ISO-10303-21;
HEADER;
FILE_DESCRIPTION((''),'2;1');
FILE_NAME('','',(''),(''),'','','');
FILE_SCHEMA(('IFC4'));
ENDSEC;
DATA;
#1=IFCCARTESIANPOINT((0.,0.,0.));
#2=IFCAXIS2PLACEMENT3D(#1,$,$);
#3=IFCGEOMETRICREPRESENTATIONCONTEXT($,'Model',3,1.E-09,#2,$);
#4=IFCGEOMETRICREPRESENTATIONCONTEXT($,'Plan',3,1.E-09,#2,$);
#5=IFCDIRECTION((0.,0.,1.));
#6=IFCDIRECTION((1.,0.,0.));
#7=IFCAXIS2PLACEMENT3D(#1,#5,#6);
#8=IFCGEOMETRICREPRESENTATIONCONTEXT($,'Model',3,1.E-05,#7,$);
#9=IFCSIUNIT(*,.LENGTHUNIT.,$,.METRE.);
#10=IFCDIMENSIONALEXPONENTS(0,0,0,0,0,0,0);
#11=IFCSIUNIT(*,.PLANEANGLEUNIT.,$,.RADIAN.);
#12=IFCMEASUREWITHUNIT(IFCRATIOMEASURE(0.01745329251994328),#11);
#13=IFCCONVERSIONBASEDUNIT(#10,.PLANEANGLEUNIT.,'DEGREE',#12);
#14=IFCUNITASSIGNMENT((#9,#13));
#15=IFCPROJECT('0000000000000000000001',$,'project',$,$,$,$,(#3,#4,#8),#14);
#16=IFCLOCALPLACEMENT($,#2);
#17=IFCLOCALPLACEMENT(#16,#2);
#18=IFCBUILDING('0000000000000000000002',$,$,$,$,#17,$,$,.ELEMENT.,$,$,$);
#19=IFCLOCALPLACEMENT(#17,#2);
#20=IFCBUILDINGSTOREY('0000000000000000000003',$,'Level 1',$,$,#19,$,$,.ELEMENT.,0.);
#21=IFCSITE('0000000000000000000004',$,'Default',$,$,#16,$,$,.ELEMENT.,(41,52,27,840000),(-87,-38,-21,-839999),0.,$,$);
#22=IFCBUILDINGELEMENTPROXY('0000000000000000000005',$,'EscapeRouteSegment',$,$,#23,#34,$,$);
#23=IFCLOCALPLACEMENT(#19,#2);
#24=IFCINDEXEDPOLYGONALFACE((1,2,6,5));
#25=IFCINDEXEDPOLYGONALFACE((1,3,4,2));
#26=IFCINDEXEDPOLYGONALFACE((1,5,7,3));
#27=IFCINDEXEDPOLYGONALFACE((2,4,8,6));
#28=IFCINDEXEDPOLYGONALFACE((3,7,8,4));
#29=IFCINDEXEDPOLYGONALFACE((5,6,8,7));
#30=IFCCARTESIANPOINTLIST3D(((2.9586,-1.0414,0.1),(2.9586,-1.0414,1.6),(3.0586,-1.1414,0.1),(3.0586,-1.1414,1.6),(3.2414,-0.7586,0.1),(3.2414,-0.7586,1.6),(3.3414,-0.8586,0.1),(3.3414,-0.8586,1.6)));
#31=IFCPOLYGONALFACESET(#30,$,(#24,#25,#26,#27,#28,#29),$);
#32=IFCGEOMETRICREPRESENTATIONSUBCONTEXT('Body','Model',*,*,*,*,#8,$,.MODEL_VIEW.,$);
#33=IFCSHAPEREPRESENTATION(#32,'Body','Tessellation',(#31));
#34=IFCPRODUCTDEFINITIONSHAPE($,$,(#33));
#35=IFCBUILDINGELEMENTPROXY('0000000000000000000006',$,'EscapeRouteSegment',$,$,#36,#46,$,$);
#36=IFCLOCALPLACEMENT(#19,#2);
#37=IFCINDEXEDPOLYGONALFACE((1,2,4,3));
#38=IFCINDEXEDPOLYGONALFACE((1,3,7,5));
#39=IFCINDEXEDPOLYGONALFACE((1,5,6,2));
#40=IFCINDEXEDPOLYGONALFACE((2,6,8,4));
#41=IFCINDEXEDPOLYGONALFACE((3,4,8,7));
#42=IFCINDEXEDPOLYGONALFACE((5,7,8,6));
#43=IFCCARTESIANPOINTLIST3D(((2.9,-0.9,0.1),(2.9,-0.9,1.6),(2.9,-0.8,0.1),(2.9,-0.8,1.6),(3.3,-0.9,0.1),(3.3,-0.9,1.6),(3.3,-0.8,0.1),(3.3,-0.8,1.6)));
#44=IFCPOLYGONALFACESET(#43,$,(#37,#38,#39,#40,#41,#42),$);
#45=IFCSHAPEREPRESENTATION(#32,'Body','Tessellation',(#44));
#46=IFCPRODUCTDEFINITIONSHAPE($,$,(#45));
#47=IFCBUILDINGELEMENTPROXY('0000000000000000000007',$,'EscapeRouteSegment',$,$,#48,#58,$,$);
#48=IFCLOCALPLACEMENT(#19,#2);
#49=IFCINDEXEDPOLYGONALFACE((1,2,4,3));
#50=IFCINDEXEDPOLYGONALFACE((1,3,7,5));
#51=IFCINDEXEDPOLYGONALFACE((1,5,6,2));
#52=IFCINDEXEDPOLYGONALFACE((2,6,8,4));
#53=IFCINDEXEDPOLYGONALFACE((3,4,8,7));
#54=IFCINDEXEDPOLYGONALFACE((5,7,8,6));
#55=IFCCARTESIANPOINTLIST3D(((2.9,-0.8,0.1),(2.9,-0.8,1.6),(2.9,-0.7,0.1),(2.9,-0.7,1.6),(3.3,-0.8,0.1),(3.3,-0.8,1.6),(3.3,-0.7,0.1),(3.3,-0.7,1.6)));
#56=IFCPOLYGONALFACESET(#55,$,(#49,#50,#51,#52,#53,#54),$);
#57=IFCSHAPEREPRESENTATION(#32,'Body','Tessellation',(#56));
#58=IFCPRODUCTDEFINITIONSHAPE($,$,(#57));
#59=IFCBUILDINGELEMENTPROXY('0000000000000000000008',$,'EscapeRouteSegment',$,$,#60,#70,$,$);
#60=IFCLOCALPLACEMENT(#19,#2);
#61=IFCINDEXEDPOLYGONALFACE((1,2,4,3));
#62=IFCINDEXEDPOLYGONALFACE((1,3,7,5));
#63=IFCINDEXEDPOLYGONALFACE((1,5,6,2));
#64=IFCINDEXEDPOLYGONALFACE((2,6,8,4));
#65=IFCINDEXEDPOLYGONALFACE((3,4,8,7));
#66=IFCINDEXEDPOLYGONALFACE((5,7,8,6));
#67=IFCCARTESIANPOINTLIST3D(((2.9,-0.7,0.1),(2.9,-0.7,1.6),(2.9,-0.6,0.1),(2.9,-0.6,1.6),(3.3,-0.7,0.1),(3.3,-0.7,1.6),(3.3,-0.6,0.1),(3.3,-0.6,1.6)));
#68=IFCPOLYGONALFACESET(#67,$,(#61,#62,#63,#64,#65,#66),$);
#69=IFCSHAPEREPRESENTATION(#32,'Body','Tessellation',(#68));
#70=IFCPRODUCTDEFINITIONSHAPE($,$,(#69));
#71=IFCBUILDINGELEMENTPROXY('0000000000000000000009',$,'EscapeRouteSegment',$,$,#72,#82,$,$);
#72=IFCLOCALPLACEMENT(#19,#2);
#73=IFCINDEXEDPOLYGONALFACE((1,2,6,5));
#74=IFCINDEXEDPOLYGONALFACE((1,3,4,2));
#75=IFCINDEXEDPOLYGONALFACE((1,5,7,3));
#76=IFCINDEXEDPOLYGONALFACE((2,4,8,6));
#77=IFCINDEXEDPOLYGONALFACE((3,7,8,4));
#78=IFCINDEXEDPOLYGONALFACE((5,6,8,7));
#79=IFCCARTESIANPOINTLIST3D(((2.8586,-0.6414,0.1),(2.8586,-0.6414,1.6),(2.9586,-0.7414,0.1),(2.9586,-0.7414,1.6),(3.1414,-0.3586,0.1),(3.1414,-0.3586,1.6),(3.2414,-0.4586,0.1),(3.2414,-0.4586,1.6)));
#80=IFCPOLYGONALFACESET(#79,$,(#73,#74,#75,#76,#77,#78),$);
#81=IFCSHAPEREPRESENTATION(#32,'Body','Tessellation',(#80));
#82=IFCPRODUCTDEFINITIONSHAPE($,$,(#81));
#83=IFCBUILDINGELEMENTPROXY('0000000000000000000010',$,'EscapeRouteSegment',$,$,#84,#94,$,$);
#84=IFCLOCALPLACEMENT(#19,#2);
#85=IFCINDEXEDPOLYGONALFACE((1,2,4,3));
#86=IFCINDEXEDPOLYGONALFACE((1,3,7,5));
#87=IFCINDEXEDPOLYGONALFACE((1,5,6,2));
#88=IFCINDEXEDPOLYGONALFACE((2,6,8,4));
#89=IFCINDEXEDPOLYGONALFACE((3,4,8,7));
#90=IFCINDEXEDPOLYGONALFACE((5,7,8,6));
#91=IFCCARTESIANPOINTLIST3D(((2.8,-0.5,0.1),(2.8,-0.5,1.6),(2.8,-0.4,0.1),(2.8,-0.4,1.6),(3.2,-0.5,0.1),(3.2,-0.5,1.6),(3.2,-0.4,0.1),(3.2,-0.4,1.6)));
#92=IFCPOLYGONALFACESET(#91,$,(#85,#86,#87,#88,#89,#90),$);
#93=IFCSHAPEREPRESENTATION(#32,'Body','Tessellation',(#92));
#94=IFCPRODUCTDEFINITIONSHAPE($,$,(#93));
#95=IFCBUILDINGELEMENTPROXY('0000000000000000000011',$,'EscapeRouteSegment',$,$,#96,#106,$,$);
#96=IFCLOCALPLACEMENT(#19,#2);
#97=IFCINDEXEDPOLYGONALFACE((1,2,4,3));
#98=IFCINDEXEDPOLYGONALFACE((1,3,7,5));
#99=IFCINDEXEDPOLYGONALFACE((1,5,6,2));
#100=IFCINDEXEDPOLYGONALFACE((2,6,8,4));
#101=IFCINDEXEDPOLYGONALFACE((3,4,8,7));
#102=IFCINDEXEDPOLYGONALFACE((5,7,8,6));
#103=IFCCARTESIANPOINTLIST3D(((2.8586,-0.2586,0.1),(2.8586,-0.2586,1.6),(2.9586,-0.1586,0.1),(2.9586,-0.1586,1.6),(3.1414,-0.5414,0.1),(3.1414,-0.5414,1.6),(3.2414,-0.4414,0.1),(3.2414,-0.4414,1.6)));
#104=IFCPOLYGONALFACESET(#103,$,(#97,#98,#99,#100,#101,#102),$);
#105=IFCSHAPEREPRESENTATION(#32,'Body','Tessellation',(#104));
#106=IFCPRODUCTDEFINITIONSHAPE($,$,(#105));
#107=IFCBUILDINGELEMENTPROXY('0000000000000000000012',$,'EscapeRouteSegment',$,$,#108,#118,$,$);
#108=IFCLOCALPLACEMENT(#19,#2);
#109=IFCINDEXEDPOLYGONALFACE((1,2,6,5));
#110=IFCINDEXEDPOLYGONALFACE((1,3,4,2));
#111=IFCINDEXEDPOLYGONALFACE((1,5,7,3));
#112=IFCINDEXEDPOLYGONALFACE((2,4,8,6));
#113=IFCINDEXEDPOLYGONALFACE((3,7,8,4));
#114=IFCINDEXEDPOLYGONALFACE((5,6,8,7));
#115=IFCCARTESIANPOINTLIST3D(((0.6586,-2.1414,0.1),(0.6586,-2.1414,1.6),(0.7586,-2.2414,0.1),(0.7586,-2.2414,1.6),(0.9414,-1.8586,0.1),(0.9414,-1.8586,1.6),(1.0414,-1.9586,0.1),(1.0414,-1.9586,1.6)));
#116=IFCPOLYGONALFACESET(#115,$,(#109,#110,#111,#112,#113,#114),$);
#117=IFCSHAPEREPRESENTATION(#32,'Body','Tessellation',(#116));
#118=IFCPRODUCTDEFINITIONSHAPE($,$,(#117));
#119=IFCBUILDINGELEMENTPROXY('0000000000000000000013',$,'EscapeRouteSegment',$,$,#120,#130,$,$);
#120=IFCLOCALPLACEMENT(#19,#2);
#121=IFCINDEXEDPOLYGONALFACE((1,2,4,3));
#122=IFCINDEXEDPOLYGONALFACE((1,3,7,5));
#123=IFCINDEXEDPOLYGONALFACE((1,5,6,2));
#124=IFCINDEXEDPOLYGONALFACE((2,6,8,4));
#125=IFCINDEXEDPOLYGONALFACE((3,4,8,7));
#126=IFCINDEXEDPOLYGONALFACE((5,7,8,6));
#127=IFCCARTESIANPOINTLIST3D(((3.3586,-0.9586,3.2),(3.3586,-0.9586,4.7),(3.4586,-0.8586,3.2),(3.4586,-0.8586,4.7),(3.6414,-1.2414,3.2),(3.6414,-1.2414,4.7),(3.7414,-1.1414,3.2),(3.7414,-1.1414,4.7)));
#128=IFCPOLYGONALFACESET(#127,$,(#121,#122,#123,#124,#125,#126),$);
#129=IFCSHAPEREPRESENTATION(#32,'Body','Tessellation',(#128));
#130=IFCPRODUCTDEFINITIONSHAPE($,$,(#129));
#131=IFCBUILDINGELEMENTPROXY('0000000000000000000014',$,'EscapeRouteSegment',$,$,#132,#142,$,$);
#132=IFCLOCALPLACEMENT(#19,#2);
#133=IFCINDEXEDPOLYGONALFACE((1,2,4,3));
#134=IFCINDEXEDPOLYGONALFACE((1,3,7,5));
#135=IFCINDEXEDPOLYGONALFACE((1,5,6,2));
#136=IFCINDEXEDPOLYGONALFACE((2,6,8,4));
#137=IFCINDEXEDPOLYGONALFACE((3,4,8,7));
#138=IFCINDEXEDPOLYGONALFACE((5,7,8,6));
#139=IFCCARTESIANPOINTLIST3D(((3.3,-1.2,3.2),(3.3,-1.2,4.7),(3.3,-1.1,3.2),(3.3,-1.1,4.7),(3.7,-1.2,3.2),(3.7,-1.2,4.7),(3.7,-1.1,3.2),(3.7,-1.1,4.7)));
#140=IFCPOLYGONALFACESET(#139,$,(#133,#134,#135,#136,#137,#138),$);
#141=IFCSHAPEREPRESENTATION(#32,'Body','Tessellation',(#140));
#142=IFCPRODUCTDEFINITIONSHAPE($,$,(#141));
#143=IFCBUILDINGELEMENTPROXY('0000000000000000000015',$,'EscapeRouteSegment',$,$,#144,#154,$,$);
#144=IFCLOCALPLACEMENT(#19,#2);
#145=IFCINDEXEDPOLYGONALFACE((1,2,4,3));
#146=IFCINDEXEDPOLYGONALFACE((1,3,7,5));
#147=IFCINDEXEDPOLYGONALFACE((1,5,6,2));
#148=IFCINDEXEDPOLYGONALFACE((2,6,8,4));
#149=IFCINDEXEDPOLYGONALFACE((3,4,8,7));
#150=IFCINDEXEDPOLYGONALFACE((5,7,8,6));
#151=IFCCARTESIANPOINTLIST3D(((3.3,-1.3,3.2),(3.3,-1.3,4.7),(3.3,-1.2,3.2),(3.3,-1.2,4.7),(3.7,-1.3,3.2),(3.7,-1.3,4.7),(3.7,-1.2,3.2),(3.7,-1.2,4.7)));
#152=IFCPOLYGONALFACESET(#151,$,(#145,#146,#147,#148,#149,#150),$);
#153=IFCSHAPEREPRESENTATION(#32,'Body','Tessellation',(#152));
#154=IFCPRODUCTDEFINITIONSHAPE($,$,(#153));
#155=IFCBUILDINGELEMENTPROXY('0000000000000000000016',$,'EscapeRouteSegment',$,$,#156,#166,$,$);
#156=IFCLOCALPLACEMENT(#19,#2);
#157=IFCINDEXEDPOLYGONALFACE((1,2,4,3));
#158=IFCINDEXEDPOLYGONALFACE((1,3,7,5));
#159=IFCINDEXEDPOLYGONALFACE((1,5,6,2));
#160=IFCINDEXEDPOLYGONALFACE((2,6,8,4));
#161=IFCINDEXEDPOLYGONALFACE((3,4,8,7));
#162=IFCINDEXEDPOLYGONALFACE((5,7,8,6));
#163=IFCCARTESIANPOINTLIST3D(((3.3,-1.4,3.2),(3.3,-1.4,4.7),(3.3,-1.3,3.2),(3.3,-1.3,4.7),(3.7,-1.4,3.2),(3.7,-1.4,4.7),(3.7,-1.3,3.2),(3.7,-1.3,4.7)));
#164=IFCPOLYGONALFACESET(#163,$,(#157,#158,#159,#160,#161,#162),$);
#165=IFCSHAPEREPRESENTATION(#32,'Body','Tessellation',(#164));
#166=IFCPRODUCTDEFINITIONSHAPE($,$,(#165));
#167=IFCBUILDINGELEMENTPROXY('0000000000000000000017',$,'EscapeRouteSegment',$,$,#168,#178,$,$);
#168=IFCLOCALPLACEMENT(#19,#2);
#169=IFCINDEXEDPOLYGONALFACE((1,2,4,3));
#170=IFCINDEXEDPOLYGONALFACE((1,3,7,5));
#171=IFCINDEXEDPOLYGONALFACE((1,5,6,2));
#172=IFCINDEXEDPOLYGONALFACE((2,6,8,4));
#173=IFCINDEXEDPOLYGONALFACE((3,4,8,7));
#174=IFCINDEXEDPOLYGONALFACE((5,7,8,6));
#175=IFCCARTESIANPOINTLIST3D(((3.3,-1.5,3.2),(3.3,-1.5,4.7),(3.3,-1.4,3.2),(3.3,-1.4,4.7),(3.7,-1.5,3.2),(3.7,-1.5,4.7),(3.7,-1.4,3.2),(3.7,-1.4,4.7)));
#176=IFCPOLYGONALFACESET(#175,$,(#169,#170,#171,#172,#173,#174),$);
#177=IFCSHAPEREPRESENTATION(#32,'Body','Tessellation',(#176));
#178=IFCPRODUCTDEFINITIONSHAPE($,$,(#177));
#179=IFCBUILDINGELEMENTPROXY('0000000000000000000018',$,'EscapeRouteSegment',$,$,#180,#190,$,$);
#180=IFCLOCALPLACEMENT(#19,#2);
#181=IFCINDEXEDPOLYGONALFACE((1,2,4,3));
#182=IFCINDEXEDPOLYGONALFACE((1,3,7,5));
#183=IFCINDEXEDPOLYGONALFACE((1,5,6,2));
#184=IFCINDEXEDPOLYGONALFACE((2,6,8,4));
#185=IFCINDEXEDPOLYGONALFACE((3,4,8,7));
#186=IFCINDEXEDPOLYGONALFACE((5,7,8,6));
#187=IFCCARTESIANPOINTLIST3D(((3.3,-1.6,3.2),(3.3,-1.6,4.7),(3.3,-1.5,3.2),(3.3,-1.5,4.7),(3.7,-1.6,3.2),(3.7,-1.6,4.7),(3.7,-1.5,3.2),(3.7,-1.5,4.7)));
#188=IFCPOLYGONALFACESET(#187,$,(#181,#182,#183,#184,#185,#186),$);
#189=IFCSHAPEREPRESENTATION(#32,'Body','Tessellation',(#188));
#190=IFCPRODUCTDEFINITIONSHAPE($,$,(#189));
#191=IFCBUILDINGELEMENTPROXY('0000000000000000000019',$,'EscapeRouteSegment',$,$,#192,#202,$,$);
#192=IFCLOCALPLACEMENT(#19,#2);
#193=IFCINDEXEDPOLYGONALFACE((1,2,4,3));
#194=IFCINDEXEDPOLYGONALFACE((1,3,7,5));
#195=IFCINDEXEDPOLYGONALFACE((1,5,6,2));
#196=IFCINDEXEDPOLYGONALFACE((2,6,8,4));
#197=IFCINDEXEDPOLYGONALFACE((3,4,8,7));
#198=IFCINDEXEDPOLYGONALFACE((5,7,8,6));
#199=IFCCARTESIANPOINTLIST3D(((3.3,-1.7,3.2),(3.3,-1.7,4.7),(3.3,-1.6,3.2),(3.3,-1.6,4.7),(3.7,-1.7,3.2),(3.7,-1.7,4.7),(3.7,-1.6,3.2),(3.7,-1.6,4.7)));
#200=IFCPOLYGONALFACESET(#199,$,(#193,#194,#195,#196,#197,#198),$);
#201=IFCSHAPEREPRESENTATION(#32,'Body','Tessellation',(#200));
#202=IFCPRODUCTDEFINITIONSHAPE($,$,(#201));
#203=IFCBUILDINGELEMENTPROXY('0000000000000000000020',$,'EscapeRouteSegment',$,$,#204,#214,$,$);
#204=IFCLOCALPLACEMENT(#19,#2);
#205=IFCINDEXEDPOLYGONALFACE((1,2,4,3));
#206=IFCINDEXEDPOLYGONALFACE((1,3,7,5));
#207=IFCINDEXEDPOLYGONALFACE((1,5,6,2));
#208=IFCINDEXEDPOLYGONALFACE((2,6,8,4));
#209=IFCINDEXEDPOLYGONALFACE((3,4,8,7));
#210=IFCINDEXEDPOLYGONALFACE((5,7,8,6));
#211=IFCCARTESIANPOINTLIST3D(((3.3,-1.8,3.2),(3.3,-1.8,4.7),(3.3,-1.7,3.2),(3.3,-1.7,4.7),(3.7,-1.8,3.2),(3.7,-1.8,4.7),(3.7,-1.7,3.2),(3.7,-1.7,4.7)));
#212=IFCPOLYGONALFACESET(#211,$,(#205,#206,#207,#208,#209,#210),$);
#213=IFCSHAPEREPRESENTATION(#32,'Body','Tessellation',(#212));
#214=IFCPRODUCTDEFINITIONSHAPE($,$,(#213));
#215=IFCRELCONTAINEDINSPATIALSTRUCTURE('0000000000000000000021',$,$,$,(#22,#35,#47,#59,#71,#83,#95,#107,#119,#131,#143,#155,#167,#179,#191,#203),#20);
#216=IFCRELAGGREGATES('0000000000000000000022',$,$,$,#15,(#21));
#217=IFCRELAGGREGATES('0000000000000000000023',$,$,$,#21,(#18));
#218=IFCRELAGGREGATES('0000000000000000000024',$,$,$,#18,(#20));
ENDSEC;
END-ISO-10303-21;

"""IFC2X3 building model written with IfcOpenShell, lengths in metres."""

from ifc_helpers import new_model, entity, si_unit, converted_unit, frame, origin, origin_with_axes, place, context, subcontext, project, spatial, polyline, outline, extrude, element, save


model = new_model("IFC2X3")

# Units and contexts
model_context_1 = context("Model", 3, precision=1e-09, world=origin())
plan_context = context("Plan", 3, precision=1e-09, world=origin())
model_context_2 = context("Model", 3, precision=1e-05, world=origin_with_axes())
body_context = subcontext(model_context_2, "Body", "Model", "MODEL_VIEW")
ifc_project = project(units=[si_unit("LENGTHUNIT", "METRE"), converted_unit("PLANEANGLEUNIT", "DEGREE", entity("IfcRatioMeasure", 0.01745329251994328), si_unit("PLANEANGLEUNIT", "RADIAN"), dimensions=[0, 0, 0, 0, 0, 0, 0])], contexts=[model_context_1, plan_context, model_context_2])

# Site, building, storey
site_placement = place(None, origin())
site = spatial("IfcSite", under=ifc_project, at=site_placement, Name="Default", CompositionType="ELEMENT", RefLatitude=(41, 52, 27, 840000), RefLongitude=(-87, -38, -21, -839999), RefElevation=0.0)
building_placement = place(site_placement, origin())
building = spatial("IfcBuilding", under=site, at=building_placement, CompositionType="ELEMENT")
storey_placement = place(building_placement, origin())
storey = spatial("IfcBuildingStorey", under=building, at=storey_placement, Name="Level 1", CompositionType="ELEMENT", Elevation=0.0)

# Building element proxies
proxy_1_placement = place(storey_placement, frame((3.2, -1.0, 0.1), z_axis=(0.0, 0.0, 1.0), x_axis=(-0.707107, 0.707106, 0.0)))
element("IfcBuildingElementProxy", 1, at=proxy_1_placement, inside=storey, Name="EscapeRouteSegment", context=body_context, shape_type="SweptSolid", body=[
    extrude(outline(polyline([(0.0, -0.2), (0.0, 0.2), (0.1414, 0.2), (0.1414, -0.2), (0.0, -0.2)])), origin_with_axes(), (0.0, 0.0, 1.0), 1.5),
])
proxy_2_placement = place(storey_placement, frame((3.1, -0.9, 0.1), z_axis=(0.0, 0.0, 1.0), x_axis=(0.0, 1.0, 0.0)))
element("IfcBuildingElementProxy", 2, at=proxy_2_placement, inside=storey, Name="EscapeRouteSegment", context=body_context, shape_type="SweptSolid", body=[
    extrude(outline(polyline([(0.0, -0.2), (0.0, 0.2), (0.1, 0.2), (0.1, -0.2), (0.0, -0.2)])), origin_with_axes(), (0.0, 0.0, 1.0), 1.5),
])
proxy_3_placement = place(storey_placement, frame((3.1, -0.8, 0.1), z_axis=(0.0, 0.0, 1.0), x_axis=(0.0, 1.0, 0.0)))
element("IfcBuildingElementProxy", 3, at=proxy_3_placement, inside=storey, Name="EscapeRouteSegment", context=body_context, shape_type="SweptSolid", body=[
    extrude(outline(polyline([(0.0, -0.2), (0.0, 0.2), (0.1, 0.2), (0.1, -0.2), (0.0, -0.2)])), origin_with_axes(), (0.0, 0.0, 1.0), 1.5),
])
proxy_4_placement = place(storey_placement, frame((3.1, -0.7, 0.1), z_axis=(0.0, 0.0, 1.0), x_axis=(0.0, 1.0, 0.0)))
element("IfcBuildingElementProxy", 4, at=proxy_4_placement, inside=storey, Name="EscapeRouteSegment", context=body_context, shape_type="SweptSolid", body=[
    extrude(outline(polyline([(0.0, -0.2), (0.0, 0.2), (0.1, 0.2), (0.1, -0.2), (0.0, -0.2)])), origin_with_axes(), (0.0, 0.0, 1.0), 1.5),
])
proxy_5_placement = place(storey_placement, frame((3.1, -0.6, 0.1), z_axis=(0.0, 0.0, 1.0), x_axis=(-0.707106, 0.707107, 0.0)))
element("IfcBuildingElementProxy", 5, at=proxy_5_placement, inside=storey, Name="EscapeRouteSegment", context=body_context, shape_type="SweptSolid", body=[
    extrude(outline(polyline([(0.0, -0.2), (0.0, 0.2), (0.1414, 0.2), (0.1414, -0.2), (0.0, -0.2)])), origin_with_axes(), (0.0, 0.0, 1.0), 1.5),
])
proxy_6_placement = place(storey_placement, frame((3.0, -0.5, 0.1), z_axis=(0.0, 0.0, 1.0), x_axis=(0.0, 1.0, 0.0)))
element("IfcBuildingElementProxy", 6, at=proxy_6_placement, inside=storey, Name="EscapeRouteSegment", context=body_context, shape_type="SweptSolid", body=[
    extrude(outline(polyline([(0.0, -0.2), (0.0, 0.2), (0.1, 0.2), (0.1, -0.2), (0.0, -0.2)])), origin_with_axes(), (0.0, 0.0, 1.0), 1.5),
])
proxy_7_placement = place(storey_placement, frame((3.0, -0.4, 0.1), z_axis=(0.0, 0.0, 1.0), x_axis=(0.707106, 0.707107, 0.0)))
element("IfcBuildingElementProxy", 7, at=proxy_7_placement, inside=storey, Name="EscapeRouteSegment", context=body_context, shape_type="SweptSolid", body=[
    extrude(outline(polyline([(0.0, -0.2), (0.0, 0.2), (0.1414, 0.2), (0.1414, -0.2), (0.0, -0.2)])), origin_with_axes(), (0.0, 0.0, 1.0), 1.5),
])
for number, where, z_axis, x_axis, name in (
    (8, (0.9, -2.1, 0.1), (0.0, 0.0, 1.0), (-0.707107, 0.707107, 0.0), "EscapeRouteSegment"),
):
    element("IfcBuildingElementProxy", number, at=place(storey_placement, frame(where, z_axis=z_axis, x_axis=x_axis)), inside=storey, Name=name, context=body_context, shape_type="SweptSolid", body=[
        extrude(outline(polyline([(0.0, -0.2), (0.0, 0.2), (0.1414, 0.2), (0.1414, -0.2), (0.0, -0.2)])), origin_with_axes(), (0.0, 0.0, 1.0), 1.5),
    ])
proxy_8_placement = place(storey_placement, frame((3.6, -1.0, 3.2), z_axis=(0.0, 0.0, 1.0), x_axis=(-0.707106, -0.707107, 0.0)))
element("IfcBuildingElementProxy", 9, at=proxy_8_placement, inside=storey, Name="EscapeRouteSegment", context=body_context, shape_type="SweptSolid", body=[
    extrude(outline(polyline([(0.0, -0.2), (0.0, 0.2), (0.1414, 0.2), (0.1414, -0.2), (0.0, -0.2)])), origin_with_axes(), (0.0, 0.0, 1.0), 1.5),
])
proxy_9_placement = place(storey_placement, frame((3.5, -1.1, 3.2), z_axis=(0.0, 0.0, 1.0), x_axis=(0.0, -1.0, 0.0)))
element("IfcBuildingElementProxy", 10, at=proxy_9_placement, inside=storey, Name="EscapeRouteSegment", context=body_context, shape_type="SweptSolid", body=[
    extrude(outline(polyline([(0.0, -0.2), (0.0, 0.2), (0.1, 0.2), (0.1, -0.2), (0.0, -0.2)])), origin_with_axes(), (0.0, 0.0, 1.0), 1.5),
])
proxy_10_placement = place(storey_placement, frame((3.5, -1.2, 3.2), z_axis=(0.0, 0.0, 1.0), x_axis=(0.0, -1.0, 0.0)))
element("IfcBuildingElementProxy", 11, at=proxy_10_placement, inside=storey, Name="EscapeRouteSegment", context=body_context, shape_type="SweptSolid", body=[
    extrude(outline(polyline([(0.0, -0.2), (0.0, 0.2), (0.1, 0.2), (0.1, -0.2), (0.0, -0.2)])), origin_with_axes(), (0.0, 0.0, 1.0), 1.5),
])
for number, where, z_axis, x_axis, name in (
    (12, (3.5, -1.3, 3.2), (0.0, 0.0, 1.0), (0.0, -1.0, 0.0), "EscapeRouteSegment"),
    (13, (3.5, -1.4, 3.2), (0.0, 0.0, 1.0), (0.0, -1.0, 0.0), "EscapeRouteSegment"),
    (14, (3.5, -1.5, 3.2), (0.0, 0.0, 1.0), (0.0, -1.0, 0.0), "EscapeRouteSegment"),
    (15, (3.5, -1.6, 3.2), (0.0, 0.0, 1.0), (0.0, -1.0, 0.0), "EscapeRouteSegment"),
):
    element("IfcBuildingElementProxy", number, at=place(storey_placement, frame(where, z_axis=z_axis, x_axis=x_axis)), inside=storey, Name=name, context=body_context, shape_type="SweptSolid", body=[
        extrude(outline(polyline([(0.0, -0.2), (0.0, 0.2), (0.1, 0.2), (0.1, -0.2), (0.0, -0.2)])), origin_with_axes(), (0.0, 0.0, 1.0), 1.5),
    ])
proxy_11_placement = place(storey_placement, frame((3.5, -1.7, 3.2), z_axis=(0.0, 0.0, 1.0), x_axis=(0.0, -1.0, 0.0)))
element("IfcBuildingElementProxy", 16, at=proxy_11_placement, inside=storey, Name="EscapeRouteSegment", context=body_context, shape_type="SweptSolid", body=[
    extrude(outline(polyline([(0.0, -0.2), (0.0, 0.2), (0.1, 0.2), (0.1, -0.2), (0.0, -0.2)])), origin_with_axes(), (0.0, 0.0, 1.0), 1.5),
])

save(model, "model.ifc")
